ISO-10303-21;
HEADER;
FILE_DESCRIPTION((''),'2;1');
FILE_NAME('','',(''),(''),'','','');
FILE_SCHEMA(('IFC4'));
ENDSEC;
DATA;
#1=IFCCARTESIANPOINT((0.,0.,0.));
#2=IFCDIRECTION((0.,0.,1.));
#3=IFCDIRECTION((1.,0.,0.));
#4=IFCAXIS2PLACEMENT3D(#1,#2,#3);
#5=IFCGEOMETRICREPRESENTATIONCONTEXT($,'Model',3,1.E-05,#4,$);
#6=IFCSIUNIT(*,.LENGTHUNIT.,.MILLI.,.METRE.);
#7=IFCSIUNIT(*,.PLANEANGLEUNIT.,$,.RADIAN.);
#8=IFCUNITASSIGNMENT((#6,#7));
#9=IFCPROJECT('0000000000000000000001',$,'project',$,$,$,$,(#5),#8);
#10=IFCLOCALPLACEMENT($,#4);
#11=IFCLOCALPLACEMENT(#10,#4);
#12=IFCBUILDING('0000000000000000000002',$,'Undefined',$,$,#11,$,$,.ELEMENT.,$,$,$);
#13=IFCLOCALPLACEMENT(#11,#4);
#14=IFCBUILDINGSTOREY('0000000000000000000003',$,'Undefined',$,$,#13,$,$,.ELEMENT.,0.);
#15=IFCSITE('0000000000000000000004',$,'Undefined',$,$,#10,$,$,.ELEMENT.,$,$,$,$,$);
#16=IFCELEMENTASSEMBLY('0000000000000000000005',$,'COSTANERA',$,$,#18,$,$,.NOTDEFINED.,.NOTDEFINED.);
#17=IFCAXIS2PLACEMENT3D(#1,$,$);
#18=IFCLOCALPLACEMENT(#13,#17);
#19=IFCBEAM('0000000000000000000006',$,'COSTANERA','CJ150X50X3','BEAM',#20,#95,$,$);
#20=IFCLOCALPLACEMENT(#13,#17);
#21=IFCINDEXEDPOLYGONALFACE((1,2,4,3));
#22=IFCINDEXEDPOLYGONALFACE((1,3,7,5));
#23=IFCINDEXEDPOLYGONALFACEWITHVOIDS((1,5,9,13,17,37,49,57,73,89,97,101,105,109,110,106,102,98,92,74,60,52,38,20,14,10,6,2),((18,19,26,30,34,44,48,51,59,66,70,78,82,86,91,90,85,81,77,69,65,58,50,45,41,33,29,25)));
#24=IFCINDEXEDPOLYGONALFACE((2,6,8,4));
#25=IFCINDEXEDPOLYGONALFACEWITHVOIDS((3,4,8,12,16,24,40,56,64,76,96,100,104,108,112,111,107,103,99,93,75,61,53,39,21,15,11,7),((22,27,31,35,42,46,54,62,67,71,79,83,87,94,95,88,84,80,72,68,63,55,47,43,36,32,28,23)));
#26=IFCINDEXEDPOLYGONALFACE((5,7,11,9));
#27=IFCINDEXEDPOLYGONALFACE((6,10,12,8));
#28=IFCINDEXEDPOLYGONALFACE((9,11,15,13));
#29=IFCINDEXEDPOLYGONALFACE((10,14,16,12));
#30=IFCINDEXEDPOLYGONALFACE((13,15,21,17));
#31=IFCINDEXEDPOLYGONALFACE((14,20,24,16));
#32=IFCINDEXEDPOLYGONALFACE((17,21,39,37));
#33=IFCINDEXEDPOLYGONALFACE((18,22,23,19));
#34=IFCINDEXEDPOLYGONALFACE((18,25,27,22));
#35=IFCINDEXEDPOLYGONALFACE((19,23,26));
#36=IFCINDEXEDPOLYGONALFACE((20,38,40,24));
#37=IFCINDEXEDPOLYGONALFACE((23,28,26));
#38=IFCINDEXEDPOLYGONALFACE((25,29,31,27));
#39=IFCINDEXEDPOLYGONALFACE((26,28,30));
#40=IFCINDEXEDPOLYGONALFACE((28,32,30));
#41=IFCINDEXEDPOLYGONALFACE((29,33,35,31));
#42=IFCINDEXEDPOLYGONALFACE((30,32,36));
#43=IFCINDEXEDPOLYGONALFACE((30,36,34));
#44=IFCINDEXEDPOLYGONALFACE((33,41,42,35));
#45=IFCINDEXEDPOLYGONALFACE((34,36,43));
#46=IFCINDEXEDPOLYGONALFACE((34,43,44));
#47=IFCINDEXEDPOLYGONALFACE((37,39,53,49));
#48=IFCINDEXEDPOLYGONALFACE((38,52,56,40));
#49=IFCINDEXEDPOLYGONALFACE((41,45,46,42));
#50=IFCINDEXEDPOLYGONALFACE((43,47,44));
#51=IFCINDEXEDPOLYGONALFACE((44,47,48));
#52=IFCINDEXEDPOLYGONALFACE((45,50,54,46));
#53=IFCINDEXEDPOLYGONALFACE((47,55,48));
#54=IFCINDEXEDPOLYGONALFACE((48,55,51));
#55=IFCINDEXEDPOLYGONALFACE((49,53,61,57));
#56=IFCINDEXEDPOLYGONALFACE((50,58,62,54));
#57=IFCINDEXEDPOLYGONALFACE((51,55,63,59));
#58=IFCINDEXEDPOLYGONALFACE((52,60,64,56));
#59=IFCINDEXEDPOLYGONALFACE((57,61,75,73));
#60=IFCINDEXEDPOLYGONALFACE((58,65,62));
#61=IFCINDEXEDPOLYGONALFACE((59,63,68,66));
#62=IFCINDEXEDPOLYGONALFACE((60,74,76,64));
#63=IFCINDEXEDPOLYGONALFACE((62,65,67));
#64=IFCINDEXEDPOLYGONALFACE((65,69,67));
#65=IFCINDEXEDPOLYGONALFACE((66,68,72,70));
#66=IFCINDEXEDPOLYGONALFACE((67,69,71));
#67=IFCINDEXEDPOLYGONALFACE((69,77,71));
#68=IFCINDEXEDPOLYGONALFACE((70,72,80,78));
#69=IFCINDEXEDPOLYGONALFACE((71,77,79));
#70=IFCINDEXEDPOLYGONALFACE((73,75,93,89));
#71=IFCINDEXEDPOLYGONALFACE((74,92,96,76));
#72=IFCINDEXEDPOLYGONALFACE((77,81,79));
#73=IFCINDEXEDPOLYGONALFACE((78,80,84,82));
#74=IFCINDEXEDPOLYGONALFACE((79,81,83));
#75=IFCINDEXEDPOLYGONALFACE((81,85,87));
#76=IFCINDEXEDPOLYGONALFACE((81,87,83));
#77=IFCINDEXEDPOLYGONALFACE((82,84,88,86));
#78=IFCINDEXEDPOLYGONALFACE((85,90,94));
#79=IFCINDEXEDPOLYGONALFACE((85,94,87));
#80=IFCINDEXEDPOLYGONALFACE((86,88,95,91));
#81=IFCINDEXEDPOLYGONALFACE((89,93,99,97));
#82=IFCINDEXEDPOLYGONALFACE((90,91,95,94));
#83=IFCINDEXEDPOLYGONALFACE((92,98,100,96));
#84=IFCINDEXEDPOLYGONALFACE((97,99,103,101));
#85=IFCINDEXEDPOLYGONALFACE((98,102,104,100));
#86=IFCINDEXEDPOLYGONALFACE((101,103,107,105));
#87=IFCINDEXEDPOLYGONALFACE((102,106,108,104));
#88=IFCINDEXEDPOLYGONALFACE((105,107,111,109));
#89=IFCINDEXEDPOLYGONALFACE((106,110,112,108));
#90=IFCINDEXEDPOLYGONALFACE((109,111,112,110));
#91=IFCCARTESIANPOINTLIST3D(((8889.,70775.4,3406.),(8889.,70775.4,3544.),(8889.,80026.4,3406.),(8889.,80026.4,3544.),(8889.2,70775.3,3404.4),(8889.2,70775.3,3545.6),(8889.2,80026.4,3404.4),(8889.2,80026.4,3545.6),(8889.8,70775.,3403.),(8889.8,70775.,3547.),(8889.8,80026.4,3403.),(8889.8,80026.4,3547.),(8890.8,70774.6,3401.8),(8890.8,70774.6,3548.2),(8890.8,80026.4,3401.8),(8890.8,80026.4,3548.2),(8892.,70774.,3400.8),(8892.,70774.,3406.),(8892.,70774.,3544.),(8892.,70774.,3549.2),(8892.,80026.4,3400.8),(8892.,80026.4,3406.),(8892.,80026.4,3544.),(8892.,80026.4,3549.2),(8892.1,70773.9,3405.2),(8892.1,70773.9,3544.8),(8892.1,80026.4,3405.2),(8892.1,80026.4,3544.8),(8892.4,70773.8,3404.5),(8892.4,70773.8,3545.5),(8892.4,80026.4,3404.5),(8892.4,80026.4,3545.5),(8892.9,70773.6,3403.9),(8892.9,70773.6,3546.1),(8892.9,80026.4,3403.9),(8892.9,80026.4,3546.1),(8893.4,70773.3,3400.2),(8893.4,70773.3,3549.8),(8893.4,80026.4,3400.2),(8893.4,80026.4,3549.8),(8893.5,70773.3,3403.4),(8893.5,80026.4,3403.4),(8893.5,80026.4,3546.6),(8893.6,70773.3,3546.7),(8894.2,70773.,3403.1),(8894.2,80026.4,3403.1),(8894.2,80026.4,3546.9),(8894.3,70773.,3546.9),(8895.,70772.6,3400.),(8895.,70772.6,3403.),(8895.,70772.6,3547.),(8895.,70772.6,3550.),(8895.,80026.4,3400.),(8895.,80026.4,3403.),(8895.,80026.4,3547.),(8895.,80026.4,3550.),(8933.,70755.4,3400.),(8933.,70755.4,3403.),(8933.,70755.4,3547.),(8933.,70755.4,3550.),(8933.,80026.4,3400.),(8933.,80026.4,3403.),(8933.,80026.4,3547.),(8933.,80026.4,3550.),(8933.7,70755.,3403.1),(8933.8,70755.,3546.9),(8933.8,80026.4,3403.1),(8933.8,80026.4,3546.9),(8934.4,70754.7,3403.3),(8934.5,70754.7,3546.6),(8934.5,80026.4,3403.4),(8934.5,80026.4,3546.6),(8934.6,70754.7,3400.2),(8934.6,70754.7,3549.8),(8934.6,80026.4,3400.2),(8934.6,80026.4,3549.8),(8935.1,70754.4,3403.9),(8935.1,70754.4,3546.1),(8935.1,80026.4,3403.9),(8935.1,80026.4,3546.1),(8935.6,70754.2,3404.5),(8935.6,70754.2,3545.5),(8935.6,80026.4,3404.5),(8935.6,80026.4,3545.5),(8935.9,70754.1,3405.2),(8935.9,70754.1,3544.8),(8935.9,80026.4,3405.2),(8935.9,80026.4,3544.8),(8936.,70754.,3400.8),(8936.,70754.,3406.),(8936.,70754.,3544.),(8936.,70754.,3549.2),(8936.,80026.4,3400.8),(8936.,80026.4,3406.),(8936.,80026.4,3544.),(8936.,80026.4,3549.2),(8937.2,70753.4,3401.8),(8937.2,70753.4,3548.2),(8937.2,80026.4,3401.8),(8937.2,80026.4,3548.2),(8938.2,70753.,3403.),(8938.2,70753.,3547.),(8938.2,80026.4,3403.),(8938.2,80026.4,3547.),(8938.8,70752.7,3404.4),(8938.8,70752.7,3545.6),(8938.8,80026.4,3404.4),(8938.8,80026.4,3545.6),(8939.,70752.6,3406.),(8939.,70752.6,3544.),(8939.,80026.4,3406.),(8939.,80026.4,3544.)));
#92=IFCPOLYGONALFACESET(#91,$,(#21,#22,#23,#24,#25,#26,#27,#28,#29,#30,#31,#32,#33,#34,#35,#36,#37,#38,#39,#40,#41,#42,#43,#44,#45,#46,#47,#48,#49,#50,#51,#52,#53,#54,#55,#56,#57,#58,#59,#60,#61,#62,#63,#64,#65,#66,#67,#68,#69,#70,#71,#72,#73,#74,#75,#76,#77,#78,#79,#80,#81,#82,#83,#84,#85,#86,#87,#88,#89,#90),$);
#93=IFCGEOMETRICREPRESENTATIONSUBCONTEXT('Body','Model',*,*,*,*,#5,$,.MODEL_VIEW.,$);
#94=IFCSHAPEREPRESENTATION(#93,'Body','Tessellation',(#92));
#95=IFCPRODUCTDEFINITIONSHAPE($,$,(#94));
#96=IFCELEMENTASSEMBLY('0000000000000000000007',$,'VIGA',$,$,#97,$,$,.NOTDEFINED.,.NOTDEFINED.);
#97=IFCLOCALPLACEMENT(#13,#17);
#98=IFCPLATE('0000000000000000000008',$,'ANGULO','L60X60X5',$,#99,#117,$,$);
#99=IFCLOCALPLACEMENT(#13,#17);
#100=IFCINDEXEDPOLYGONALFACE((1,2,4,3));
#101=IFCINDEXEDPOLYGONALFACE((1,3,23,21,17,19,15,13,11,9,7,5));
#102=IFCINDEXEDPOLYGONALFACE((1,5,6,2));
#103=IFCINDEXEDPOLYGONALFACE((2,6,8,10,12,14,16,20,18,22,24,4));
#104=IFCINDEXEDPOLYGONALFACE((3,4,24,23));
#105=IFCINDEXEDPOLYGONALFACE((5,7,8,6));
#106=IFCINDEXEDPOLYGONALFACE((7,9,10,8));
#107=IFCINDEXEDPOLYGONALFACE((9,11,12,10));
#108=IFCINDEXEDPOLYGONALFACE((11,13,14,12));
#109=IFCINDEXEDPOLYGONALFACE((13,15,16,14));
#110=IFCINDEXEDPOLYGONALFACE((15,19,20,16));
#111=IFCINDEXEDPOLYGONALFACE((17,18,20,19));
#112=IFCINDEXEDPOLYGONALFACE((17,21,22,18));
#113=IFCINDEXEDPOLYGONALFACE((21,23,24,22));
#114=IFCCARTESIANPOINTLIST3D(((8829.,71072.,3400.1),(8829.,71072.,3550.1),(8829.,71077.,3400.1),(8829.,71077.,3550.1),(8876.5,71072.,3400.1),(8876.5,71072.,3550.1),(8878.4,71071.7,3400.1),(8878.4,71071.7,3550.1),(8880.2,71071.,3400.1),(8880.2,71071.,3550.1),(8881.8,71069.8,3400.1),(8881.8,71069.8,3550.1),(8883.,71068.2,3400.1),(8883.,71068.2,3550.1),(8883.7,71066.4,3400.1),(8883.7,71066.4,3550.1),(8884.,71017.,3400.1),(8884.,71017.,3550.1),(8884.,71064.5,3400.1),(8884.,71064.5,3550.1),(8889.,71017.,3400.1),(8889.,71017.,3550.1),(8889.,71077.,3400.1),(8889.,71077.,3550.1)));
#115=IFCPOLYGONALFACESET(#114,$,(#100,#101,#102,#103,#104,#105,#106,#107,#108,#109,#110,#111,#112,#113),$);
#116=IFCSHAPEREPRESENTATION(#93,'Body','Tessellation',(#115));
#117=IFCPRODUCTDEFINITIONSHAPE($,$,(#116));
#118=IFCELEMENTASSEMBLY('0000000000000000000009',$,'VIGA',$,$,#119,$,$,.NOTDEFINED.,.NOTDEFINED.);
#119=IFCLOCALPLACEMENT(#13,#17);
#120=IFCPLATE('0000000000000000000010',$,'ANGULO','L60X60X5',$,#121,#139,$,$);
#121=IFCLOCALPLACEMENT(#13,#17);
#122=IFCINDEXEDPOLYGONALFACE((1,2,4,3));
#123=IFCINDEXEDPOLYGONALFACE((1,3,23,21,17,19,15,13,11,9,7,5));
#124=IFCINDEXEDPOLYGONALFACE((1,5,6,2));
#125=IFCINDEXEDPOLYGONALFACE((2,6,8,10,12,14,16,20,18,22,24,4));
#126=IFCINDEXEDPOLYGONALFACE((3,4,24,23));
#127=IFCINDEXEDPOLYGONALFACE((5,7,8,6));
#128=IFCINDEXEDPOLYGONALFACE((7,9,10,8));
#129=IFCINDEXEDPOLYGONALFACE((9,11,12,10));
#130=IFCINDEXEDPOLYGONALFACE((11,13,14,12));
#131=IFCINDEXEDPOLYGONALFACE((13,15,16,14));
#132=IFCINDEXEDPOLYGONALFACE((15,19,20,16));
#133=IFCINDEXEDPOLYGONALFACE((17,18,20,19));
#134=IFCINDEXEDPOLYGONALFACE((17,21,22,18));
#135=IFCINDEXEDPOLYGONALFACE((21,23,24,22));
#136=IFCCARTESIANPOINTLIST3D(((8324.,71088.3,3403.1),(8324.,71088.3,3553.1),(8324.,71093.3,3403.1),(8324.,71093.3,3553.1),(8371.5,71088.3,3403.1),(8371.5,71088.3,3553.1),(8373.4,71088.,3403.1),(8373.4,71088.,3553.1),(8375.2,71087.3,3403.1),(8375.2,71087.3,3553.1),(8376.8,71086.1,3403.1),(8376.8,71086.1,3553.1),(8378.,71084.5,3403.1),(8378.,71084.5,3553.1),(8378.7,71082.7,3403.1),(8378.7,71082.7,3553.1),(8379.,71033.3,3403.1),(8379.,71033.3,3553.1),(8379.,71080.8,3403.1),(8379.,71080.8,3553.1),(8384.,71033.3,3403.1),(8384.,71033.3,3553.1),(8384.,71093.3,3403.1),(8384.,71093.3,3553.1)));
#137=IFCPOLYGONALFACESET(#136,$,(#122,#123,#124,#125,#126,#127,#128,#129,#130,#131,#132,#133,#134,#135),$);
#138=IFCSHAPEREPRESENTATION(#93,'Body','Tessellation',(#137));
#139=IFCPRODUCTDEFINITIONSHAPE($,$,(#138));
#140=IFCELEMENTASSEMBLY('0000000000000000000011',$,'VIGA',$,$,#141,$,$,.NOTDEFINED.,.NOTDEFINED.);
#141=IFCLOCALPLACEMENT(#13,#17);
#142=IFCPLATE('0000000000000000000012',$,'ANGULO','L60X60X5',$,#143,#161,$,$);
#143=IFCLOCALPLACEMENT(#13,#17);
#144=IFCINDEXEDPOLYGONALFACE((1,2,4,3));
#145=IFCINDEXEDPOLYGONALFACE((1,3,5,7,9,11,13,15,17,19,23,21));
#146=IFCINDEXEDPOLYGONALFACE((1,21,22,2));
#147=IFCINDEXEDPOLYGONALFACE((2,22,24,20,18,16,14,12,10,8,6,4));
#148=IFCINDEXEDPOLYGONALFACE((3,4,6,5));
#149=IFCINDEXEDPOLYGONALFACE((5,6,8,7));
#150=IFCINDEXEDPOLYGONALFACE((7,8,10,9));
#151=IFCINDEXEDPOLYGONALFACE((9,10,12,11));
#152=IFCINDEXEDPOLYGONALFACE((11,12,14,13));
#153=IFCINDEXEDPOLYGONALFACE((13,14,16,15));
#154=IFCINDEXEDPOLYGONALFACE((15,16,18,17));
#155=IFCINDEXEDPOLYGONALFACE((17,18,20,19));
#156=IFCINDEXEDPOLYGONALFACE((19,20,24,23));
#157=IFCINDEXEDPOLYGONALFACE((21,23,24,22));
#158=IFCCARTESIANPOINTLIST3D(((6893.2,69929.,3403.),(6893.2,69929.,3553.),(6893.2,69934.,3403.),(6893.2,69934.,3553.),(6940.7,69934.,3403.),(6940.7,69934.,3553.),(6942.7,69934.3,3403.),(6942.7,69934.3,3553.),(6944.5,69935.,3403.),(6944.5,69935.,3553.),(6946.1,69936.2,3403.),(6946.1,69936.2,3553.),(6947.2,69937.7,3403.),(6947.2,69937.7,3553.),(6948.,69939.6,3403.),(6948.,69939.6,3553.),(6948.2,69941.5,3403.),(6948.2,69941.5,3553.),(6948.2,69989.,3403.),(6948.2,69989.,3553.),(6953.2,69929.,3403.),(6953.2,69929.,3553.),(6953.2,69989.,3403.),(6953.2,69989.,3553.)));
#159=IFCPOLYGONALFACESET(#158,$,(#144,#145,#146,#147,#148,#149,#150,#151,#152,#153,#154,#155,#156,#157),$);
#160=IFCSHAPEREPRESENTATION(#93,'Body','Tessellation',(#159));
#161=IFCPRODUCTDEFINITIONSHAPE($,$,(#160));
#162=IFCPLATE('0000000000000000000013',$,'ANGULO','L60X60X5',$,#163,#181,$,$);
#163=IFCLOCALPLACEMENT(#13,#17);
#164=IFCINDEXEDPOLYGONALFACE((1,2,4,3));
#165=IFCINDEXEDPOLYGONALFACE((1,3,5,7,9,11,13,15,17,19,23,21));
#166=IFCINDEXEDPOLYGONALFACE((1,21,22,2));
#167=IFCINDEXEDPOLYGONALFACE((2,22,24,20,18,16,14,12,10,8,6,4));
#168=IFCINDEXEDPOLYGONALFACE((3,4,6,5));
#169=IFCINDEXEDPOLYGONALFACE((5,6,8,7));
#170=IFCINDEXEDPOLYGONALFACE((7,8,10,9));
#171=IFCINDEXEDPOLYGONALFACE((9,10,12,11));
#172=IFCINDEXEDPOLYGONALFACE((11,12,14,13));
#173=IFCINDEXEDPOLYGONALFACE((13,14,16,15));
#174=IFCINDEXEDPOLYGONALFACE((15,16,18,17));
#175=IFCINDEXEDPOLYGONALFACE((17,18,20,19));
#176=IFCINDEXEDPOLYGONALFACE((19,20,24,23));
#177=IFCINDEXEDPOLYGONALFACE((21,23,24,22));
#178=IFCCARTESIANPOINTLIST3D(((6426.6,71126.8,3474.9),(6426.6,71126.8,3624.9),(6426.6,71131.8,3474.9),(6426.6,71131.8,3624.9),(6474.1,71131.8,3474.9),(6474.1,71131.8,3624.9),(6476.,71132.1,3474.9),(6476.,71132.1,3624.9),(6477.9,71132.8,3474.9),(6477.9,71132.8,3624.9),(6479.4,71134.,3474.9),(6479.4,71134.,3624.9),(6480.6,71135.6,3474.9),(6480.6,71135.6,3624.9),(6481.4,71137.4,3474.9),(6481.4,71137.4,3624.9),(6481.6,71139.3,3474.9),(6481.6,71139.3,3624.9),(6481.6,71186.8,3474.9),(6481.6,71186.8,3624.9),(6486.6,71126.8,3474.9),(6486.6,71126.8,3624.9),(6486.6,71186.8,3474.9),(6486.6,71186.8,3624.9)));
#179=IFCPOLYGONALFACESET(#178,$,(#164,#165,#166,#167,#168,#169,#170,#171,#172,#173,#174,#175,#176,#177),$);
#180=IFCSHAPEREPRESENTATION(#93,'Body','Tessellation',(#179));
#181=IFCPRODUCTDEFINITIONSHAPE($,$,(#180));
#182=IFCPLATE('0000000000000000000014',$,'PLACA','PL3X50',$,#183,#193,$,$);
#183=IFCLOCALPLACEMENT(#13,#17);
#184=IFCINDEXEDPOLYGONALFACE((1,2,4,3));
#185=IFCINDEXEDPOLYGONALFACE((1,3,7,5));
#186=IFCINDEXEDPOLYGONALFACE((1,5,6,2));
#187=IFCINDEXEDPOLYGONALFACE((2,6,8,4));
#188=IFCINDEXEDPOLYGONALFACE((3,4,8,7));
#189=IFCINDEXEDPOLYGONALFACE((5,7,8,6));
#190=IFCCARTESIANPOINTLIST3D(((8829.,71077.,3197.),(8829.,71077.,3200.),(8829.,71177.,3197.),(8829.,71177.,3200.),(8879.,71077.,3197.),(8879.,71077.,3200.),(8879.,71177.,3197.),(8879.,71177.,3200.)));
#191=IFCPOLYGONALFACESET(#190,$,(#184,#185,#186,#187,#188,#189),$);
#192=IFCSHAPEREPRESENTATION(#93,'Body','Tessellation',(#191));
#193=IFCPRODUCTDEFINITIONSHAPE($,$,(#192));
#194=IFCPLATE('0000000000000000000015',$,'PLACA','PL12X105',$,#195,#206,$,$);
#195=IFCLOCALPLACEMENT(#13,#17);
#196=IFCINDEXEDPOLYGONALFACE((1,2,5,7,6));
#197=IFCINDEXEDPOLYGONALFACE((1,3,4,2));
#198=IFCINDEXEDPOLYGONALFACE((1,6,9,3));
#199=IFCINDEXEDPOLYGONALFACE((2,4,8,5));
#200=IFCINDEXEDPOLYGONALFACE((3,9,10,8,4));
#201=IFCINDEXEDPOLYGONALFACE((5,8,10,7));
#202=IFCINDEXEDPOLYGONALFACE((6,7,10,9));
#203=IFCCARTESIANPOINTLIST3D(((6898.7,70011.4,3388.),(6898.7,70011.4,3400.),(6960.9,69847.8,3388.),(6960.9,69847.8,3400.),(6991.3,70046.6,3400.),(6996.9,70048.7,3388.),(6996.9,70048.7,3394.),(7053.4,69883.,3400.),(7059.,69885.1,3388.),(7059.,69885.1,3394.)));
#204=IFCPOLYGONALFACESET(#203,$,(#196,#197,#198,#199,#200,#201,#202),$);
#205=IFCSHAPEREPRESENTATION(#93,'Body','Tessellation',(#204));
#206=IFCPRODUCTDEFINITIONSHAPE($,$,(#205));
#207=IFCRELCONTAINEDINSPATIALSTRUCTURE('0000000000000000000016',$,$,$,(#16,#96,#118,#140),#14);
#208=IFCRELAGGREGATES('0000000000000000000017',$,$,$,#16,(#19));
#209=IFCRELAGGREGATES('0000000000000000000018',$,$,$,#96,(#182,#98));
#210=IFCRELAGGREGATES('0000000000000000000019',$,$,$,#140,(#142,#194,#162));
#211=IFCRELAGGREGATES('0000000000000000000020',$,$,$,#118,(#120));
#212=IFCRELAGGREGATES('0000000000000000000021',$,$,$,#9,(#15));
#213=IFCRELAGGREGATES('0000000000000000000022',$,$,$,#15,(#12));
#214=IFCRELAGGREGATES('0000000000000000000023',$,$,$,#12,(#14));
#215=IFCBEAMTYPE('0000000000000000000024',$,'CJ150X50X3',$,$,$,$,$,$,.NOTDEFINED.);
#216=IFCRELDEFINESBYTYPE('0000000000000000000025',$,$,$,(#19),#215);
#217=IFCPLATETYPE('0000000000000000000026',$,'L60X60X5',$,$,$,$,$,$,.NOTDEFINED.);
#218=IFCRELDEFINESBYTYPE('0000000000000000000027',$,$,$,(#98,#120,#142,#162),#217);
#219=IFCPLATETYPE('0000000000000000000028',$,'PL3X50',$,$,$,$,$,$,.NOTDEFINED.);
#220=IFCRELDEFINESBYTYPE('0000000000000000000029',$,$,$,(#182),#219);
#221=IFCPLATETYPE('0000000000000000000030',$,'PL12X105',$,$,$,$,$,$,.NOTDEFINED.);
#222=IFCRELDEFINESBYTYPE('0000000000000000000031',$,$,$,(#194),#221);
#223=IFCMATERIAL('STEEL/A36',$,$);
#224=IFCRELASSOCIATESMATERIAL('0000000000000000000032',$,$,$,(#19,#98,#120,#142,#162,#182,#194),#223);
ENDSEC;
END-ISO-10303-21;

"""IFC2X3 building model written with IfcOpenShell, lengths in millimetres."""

from ifc_helpers import new_model, si_unit, frame, origin_with_axes, origin_2d_with_axis, place, context, subcontext, project, spatial, polyline, hollow_rectangle, l_section, outline, extrude, boolean, clip, halfspace, material, type_object, element, aggregate, save


model = new_model("IFC2X3")

# Units and contexts
model_context = context("Model", 3, precision=1e-05, world=origin_with_axes())
body_context = subcontext(model_context, "Body", "Model", "MODEL_VIEW")
ifc_project = project(units=[si_unit("LENGTHUNIT", "METRE", prefix="MILLI"), si_unit("PLANEANGLEUNIT", "RADIAN")], contexts=[model_context])

# Site, building, storey
site_placement = place(None, origin_with_axes())
site = spatial("IfcSite", under=ifc_project, at=site_placement, Name="Undefined", CompositionType="ELEMENT")
building_placement = place(site_placement, origin_with_axes())
building = spatial("IfcBuilding", under=site, at=building_placement, Name="Undefined", CompositionType="ELEMENT")
storey_placement = place(building_placement, origin_with_axes())
storey = spatial("IfcBuildingStorey", under=building, at=storey_placement, Name="Undefined", CompositionType="ELEMENT", Elevation=0.0)

# Element assembly, beam
assembly_1_placement = place(storey_placement, origin_with_axes())
assembly_1 = element("IfcElementAssembly", 1, at=assembly_1_placement, inside=storey, Name="COSTANERA", AssemblyPlace="NOTDEFINED", PredefinedType="NOTDEFINED")
ifc_material_1 = material(Name="STEEL/A36")
beam_type_1 = type_object("IfcBeamType", Name="CJ150X50X3", PredefinedType="NOTDEFINED")
beam_1_placement = place(assembly_1_placement, frame((8914.0, 70764.0, 3475.0), z_axis=(0.0, 0.0, 1.0), x_axis=(0.0, 1.0, 0.0)))
beam_1 = element("IfcBeam", 2, at=beam_1_placement, type_object=beam_type_1, material=ifc_material_1, Name="COSTANERA", Description="CJ150X50X3", ObjectType="BEAM", context=body_context, shape_type="Clipping", body=[
    clip(extrude(hollow_rectangle(XDim=50.0, YDim=150.0, WallThickness=3.0, InnerFilletRadius=3.0, OuterFilletRadius=6.0, at=origin_2d_with_axis()), frame((9262.4, 0.0, 0.0), z_axis=(-1.0, 0.0, 0.0), x_axis=(0.0, -1.0, 0.0)), (0.0, 0.0, 1.0), 9273.9), halfspace(frame((-11.4, -25.0, 0.0), z_axis=(0.910503, -0.413502, 0.0), x_axis=(0.0, 0.0, 1.0)), True)),
])
aggregate(assembly_1, [beam_1])

# Element assemblies, plates
assembly_2_placement = place(storey_placement, origin_with_axes())
assembly_2 = element("IfcElementAssembly", 3, at=assembly_2_placement, inside=storey, Name="VIGA", AssemblyPlace="NOTDEFINED", PredefinedType="NOTDEFINED")
plate_type_1 = type_object("IfcPlateType", Name="L60X60X5", PredefinedType="NOTDEFINED")
plate_1_placement = place(assembly_2_placement, frame((8859.0, 71047.0, 3400.1), z_axis=(-1.0, 0.0, 0.0), x_axis=(0.0, 0.0, 1.0)))
plate_1 = element("IfcPlate", 4, at=plate_1_placement, type_object=plate_type_1, material=ifc_material_1, Name="ANGULO", Description="L60X60X5", context=body_context, shape_type="SweptSolid", body=[
    extrude(l_section(Depth=60.0, Width=60.0, Thickness=5.0, FilletRadius=7.5, at=origin_2d_with_axis()), frame((150.0, 0.0, 0.0), z_axis=(-1.0, 0.0, 0.0), x_axis=(0.0, -1.0, 0.0)), (0.0, 0.0, 1.0), 150.0),
])
assembly_3_placement = place(storey_placement, origin_with_axes())
assembly_3 = element("IfcElementAssembly", 5, at=assembly_3_placement, inside=storey, Name="VIGA", AssemblyPlace="NOTDEFINED", PredefinedType="NOTDEFINED")
plate_2_placement = place(assembly_3_placement, frame((8354.0, 71063.3, 3403.1), z_axis=(-1.0, 0.0, 0.0), x_axis=(0.0, 0.0, 1.0)))
plate_2 = element("IfcPlate", 6, at=plate_2_placement, type_object=plate_type_1, material=ifc_material_1, Name="ANGULO", Description="L60X60X5", context=body_context, shape_type="SweptSolid", body=[
    extrude(l_section(Depth=60.0, Width=60.0, Thickness=5.0, FilletRadius=7.5, at=origin_2d_with_axis()), frame((150.0, 0.0, 0.0), z_axis=(-1.0, 0.0, 0.0), x_axis=(0.0, -1.0, 0.0)), (0.0, 0.0, 1.0), 150.0),
])

# Element assembly, plates
assembly_4_placement = place(storey_placement, origin_with_axes())
assembly_4 = element("IfcElementAssembly", 7, at=assembly_4_placement, inside=storey, Name="VIGA", AssemblyPlace="NOTDEFINED", PredefinedType="NOTDEFINED")
plate_3_placement = place(assembly_4_placement, frame((6923.2, 69959.0, 3403.0), z_axis=(0.0, 1.0, 0.0), x_axis=(0.0, 0.0, 1.0)))
plate_3 = element("IfcPlate", 8, at=plate_3_placement, type_object=plate_type_1, material=ifc_material_1, Name="ANGULO", Description="L60X60X5", context=body_context, shape_type="SweptSolid", body=[
    extrude(l_section(Depth=60.0, Width=60.0, Thickness=5.0, FilletRadius=7.5, at=origin_2d_with_axis()), frame((150.0, 0.0, 0.0), z_axis=(-1.0, 0.0, 0.0), x_axis=(0.0, -1.0, 0.0)), (0.0, 0.0, 1.0), 150.0),
])
plate_4_placement = place(assembly_4_placement, frame((6456.6, 71156.8, 3474.9), z_axis=(0.0, 1.0, 0.0), x_axis=(0.0, 0.0, 1.0)))
plate_4 = element("IfcPlate", 9, at=plate_4_placement, type_object=plate_type_1, material=ifc_material_1, Name="ANGULO", Description="L60X60X5", context=body_context, shape_type="SweptSolid", body=[
    extrude(l_section(Depth=60.0, Width=60.0, Thickness=5.0, FilletRadius=7.5, at=origin_2d_with_axis()), frame((150.0, 0.0, 0.0), z_axis=(-1.0, 0.0, 0.0), x_axis=(0.0, -1.0, 0.0)), (0.0, 0.0, 1.0), 150.0),
])

# Plates
plate_type_2 = type_object("IfcPlateType", Name="PL3X50", PredefinedType="NOTDEFINED")
plate_5_placement = place(assembly_2_placement, frame((8829.0, 71077.0, 3198.5), z_axis=(0.0, 0.0, 1.0), x_axis=(1.0, 0.0, 0.0)))
plate_5 = element("IfcPlate", 10, at=plate_5_placement, type_object=plate_type_2, material=ifc_material_1, Name="PLACA", Description="PL3X50", context=body_context, shape_type="SweptSolid", body=[
    extrude(outline(polyline([(0.0, 0.0), (50.0, 0.0), (50.0, 100.0), (0.0, 100.0), (0.0, 0.0)])), frame((0.0, 0.0, -1.5), z_axis=(0.0, 0.0, 1.0), x_axis=(1.0, 0.0, 0.0)), (0.0, 0.0, 1.0), 3.0),
])
plate_type_3 = type_object("IfcPlateType", Name="PL12X105", PredefinedType="NOTDEFINED")
plate_6_placement = place(assembly_4_placement, frame((7059.0, 69885.1, 3394.0), z_axis=(0.0, 0.0, 1.0), x_axis=(-0.354934, 0.934891, 0.0)))
plate_6 = element("IfcPlate", 11, at=plate_6_placement, type_object=plate_type_3, material=ifc_material_1, Name="PLACA", Description="PL12X105", context=body_context, shape_type="CSG", body=[
    boolean("DIFFERENCE", extrude(outline(polyline([(0.0, 0.0), (175.0, 0.0), (175.0, 105.0), (0.0, 105.0), (0.0, 0.0)])), frame((0.0, 0.0, -6.0), z_axis=(0.0, 0.0, 1.0), x_axis=(1.0, 0.0, 0.0)), (0.0, 0.0, 1.0), 12.0), extrude(outline(polyline([(0.0, 0.0), (6.0, 0.0), (6.0, 6.0), (0.0, 0.0)])), frame((-3.0, 6.0, 6.0), z_axis=(1.0, 0.0, 0.0), x_axis=(0.0, -1.0, 0.0)), (0.0, 0.0, 1.0), 181.0)),
])

aggregate(assembly_2, [plate_5, plate_1])

aggregate(assembly_4, [plate_3, plate_6, plate_4])

aggregate(assembly_3, [plate_2])

save(model, "model.ifc")
